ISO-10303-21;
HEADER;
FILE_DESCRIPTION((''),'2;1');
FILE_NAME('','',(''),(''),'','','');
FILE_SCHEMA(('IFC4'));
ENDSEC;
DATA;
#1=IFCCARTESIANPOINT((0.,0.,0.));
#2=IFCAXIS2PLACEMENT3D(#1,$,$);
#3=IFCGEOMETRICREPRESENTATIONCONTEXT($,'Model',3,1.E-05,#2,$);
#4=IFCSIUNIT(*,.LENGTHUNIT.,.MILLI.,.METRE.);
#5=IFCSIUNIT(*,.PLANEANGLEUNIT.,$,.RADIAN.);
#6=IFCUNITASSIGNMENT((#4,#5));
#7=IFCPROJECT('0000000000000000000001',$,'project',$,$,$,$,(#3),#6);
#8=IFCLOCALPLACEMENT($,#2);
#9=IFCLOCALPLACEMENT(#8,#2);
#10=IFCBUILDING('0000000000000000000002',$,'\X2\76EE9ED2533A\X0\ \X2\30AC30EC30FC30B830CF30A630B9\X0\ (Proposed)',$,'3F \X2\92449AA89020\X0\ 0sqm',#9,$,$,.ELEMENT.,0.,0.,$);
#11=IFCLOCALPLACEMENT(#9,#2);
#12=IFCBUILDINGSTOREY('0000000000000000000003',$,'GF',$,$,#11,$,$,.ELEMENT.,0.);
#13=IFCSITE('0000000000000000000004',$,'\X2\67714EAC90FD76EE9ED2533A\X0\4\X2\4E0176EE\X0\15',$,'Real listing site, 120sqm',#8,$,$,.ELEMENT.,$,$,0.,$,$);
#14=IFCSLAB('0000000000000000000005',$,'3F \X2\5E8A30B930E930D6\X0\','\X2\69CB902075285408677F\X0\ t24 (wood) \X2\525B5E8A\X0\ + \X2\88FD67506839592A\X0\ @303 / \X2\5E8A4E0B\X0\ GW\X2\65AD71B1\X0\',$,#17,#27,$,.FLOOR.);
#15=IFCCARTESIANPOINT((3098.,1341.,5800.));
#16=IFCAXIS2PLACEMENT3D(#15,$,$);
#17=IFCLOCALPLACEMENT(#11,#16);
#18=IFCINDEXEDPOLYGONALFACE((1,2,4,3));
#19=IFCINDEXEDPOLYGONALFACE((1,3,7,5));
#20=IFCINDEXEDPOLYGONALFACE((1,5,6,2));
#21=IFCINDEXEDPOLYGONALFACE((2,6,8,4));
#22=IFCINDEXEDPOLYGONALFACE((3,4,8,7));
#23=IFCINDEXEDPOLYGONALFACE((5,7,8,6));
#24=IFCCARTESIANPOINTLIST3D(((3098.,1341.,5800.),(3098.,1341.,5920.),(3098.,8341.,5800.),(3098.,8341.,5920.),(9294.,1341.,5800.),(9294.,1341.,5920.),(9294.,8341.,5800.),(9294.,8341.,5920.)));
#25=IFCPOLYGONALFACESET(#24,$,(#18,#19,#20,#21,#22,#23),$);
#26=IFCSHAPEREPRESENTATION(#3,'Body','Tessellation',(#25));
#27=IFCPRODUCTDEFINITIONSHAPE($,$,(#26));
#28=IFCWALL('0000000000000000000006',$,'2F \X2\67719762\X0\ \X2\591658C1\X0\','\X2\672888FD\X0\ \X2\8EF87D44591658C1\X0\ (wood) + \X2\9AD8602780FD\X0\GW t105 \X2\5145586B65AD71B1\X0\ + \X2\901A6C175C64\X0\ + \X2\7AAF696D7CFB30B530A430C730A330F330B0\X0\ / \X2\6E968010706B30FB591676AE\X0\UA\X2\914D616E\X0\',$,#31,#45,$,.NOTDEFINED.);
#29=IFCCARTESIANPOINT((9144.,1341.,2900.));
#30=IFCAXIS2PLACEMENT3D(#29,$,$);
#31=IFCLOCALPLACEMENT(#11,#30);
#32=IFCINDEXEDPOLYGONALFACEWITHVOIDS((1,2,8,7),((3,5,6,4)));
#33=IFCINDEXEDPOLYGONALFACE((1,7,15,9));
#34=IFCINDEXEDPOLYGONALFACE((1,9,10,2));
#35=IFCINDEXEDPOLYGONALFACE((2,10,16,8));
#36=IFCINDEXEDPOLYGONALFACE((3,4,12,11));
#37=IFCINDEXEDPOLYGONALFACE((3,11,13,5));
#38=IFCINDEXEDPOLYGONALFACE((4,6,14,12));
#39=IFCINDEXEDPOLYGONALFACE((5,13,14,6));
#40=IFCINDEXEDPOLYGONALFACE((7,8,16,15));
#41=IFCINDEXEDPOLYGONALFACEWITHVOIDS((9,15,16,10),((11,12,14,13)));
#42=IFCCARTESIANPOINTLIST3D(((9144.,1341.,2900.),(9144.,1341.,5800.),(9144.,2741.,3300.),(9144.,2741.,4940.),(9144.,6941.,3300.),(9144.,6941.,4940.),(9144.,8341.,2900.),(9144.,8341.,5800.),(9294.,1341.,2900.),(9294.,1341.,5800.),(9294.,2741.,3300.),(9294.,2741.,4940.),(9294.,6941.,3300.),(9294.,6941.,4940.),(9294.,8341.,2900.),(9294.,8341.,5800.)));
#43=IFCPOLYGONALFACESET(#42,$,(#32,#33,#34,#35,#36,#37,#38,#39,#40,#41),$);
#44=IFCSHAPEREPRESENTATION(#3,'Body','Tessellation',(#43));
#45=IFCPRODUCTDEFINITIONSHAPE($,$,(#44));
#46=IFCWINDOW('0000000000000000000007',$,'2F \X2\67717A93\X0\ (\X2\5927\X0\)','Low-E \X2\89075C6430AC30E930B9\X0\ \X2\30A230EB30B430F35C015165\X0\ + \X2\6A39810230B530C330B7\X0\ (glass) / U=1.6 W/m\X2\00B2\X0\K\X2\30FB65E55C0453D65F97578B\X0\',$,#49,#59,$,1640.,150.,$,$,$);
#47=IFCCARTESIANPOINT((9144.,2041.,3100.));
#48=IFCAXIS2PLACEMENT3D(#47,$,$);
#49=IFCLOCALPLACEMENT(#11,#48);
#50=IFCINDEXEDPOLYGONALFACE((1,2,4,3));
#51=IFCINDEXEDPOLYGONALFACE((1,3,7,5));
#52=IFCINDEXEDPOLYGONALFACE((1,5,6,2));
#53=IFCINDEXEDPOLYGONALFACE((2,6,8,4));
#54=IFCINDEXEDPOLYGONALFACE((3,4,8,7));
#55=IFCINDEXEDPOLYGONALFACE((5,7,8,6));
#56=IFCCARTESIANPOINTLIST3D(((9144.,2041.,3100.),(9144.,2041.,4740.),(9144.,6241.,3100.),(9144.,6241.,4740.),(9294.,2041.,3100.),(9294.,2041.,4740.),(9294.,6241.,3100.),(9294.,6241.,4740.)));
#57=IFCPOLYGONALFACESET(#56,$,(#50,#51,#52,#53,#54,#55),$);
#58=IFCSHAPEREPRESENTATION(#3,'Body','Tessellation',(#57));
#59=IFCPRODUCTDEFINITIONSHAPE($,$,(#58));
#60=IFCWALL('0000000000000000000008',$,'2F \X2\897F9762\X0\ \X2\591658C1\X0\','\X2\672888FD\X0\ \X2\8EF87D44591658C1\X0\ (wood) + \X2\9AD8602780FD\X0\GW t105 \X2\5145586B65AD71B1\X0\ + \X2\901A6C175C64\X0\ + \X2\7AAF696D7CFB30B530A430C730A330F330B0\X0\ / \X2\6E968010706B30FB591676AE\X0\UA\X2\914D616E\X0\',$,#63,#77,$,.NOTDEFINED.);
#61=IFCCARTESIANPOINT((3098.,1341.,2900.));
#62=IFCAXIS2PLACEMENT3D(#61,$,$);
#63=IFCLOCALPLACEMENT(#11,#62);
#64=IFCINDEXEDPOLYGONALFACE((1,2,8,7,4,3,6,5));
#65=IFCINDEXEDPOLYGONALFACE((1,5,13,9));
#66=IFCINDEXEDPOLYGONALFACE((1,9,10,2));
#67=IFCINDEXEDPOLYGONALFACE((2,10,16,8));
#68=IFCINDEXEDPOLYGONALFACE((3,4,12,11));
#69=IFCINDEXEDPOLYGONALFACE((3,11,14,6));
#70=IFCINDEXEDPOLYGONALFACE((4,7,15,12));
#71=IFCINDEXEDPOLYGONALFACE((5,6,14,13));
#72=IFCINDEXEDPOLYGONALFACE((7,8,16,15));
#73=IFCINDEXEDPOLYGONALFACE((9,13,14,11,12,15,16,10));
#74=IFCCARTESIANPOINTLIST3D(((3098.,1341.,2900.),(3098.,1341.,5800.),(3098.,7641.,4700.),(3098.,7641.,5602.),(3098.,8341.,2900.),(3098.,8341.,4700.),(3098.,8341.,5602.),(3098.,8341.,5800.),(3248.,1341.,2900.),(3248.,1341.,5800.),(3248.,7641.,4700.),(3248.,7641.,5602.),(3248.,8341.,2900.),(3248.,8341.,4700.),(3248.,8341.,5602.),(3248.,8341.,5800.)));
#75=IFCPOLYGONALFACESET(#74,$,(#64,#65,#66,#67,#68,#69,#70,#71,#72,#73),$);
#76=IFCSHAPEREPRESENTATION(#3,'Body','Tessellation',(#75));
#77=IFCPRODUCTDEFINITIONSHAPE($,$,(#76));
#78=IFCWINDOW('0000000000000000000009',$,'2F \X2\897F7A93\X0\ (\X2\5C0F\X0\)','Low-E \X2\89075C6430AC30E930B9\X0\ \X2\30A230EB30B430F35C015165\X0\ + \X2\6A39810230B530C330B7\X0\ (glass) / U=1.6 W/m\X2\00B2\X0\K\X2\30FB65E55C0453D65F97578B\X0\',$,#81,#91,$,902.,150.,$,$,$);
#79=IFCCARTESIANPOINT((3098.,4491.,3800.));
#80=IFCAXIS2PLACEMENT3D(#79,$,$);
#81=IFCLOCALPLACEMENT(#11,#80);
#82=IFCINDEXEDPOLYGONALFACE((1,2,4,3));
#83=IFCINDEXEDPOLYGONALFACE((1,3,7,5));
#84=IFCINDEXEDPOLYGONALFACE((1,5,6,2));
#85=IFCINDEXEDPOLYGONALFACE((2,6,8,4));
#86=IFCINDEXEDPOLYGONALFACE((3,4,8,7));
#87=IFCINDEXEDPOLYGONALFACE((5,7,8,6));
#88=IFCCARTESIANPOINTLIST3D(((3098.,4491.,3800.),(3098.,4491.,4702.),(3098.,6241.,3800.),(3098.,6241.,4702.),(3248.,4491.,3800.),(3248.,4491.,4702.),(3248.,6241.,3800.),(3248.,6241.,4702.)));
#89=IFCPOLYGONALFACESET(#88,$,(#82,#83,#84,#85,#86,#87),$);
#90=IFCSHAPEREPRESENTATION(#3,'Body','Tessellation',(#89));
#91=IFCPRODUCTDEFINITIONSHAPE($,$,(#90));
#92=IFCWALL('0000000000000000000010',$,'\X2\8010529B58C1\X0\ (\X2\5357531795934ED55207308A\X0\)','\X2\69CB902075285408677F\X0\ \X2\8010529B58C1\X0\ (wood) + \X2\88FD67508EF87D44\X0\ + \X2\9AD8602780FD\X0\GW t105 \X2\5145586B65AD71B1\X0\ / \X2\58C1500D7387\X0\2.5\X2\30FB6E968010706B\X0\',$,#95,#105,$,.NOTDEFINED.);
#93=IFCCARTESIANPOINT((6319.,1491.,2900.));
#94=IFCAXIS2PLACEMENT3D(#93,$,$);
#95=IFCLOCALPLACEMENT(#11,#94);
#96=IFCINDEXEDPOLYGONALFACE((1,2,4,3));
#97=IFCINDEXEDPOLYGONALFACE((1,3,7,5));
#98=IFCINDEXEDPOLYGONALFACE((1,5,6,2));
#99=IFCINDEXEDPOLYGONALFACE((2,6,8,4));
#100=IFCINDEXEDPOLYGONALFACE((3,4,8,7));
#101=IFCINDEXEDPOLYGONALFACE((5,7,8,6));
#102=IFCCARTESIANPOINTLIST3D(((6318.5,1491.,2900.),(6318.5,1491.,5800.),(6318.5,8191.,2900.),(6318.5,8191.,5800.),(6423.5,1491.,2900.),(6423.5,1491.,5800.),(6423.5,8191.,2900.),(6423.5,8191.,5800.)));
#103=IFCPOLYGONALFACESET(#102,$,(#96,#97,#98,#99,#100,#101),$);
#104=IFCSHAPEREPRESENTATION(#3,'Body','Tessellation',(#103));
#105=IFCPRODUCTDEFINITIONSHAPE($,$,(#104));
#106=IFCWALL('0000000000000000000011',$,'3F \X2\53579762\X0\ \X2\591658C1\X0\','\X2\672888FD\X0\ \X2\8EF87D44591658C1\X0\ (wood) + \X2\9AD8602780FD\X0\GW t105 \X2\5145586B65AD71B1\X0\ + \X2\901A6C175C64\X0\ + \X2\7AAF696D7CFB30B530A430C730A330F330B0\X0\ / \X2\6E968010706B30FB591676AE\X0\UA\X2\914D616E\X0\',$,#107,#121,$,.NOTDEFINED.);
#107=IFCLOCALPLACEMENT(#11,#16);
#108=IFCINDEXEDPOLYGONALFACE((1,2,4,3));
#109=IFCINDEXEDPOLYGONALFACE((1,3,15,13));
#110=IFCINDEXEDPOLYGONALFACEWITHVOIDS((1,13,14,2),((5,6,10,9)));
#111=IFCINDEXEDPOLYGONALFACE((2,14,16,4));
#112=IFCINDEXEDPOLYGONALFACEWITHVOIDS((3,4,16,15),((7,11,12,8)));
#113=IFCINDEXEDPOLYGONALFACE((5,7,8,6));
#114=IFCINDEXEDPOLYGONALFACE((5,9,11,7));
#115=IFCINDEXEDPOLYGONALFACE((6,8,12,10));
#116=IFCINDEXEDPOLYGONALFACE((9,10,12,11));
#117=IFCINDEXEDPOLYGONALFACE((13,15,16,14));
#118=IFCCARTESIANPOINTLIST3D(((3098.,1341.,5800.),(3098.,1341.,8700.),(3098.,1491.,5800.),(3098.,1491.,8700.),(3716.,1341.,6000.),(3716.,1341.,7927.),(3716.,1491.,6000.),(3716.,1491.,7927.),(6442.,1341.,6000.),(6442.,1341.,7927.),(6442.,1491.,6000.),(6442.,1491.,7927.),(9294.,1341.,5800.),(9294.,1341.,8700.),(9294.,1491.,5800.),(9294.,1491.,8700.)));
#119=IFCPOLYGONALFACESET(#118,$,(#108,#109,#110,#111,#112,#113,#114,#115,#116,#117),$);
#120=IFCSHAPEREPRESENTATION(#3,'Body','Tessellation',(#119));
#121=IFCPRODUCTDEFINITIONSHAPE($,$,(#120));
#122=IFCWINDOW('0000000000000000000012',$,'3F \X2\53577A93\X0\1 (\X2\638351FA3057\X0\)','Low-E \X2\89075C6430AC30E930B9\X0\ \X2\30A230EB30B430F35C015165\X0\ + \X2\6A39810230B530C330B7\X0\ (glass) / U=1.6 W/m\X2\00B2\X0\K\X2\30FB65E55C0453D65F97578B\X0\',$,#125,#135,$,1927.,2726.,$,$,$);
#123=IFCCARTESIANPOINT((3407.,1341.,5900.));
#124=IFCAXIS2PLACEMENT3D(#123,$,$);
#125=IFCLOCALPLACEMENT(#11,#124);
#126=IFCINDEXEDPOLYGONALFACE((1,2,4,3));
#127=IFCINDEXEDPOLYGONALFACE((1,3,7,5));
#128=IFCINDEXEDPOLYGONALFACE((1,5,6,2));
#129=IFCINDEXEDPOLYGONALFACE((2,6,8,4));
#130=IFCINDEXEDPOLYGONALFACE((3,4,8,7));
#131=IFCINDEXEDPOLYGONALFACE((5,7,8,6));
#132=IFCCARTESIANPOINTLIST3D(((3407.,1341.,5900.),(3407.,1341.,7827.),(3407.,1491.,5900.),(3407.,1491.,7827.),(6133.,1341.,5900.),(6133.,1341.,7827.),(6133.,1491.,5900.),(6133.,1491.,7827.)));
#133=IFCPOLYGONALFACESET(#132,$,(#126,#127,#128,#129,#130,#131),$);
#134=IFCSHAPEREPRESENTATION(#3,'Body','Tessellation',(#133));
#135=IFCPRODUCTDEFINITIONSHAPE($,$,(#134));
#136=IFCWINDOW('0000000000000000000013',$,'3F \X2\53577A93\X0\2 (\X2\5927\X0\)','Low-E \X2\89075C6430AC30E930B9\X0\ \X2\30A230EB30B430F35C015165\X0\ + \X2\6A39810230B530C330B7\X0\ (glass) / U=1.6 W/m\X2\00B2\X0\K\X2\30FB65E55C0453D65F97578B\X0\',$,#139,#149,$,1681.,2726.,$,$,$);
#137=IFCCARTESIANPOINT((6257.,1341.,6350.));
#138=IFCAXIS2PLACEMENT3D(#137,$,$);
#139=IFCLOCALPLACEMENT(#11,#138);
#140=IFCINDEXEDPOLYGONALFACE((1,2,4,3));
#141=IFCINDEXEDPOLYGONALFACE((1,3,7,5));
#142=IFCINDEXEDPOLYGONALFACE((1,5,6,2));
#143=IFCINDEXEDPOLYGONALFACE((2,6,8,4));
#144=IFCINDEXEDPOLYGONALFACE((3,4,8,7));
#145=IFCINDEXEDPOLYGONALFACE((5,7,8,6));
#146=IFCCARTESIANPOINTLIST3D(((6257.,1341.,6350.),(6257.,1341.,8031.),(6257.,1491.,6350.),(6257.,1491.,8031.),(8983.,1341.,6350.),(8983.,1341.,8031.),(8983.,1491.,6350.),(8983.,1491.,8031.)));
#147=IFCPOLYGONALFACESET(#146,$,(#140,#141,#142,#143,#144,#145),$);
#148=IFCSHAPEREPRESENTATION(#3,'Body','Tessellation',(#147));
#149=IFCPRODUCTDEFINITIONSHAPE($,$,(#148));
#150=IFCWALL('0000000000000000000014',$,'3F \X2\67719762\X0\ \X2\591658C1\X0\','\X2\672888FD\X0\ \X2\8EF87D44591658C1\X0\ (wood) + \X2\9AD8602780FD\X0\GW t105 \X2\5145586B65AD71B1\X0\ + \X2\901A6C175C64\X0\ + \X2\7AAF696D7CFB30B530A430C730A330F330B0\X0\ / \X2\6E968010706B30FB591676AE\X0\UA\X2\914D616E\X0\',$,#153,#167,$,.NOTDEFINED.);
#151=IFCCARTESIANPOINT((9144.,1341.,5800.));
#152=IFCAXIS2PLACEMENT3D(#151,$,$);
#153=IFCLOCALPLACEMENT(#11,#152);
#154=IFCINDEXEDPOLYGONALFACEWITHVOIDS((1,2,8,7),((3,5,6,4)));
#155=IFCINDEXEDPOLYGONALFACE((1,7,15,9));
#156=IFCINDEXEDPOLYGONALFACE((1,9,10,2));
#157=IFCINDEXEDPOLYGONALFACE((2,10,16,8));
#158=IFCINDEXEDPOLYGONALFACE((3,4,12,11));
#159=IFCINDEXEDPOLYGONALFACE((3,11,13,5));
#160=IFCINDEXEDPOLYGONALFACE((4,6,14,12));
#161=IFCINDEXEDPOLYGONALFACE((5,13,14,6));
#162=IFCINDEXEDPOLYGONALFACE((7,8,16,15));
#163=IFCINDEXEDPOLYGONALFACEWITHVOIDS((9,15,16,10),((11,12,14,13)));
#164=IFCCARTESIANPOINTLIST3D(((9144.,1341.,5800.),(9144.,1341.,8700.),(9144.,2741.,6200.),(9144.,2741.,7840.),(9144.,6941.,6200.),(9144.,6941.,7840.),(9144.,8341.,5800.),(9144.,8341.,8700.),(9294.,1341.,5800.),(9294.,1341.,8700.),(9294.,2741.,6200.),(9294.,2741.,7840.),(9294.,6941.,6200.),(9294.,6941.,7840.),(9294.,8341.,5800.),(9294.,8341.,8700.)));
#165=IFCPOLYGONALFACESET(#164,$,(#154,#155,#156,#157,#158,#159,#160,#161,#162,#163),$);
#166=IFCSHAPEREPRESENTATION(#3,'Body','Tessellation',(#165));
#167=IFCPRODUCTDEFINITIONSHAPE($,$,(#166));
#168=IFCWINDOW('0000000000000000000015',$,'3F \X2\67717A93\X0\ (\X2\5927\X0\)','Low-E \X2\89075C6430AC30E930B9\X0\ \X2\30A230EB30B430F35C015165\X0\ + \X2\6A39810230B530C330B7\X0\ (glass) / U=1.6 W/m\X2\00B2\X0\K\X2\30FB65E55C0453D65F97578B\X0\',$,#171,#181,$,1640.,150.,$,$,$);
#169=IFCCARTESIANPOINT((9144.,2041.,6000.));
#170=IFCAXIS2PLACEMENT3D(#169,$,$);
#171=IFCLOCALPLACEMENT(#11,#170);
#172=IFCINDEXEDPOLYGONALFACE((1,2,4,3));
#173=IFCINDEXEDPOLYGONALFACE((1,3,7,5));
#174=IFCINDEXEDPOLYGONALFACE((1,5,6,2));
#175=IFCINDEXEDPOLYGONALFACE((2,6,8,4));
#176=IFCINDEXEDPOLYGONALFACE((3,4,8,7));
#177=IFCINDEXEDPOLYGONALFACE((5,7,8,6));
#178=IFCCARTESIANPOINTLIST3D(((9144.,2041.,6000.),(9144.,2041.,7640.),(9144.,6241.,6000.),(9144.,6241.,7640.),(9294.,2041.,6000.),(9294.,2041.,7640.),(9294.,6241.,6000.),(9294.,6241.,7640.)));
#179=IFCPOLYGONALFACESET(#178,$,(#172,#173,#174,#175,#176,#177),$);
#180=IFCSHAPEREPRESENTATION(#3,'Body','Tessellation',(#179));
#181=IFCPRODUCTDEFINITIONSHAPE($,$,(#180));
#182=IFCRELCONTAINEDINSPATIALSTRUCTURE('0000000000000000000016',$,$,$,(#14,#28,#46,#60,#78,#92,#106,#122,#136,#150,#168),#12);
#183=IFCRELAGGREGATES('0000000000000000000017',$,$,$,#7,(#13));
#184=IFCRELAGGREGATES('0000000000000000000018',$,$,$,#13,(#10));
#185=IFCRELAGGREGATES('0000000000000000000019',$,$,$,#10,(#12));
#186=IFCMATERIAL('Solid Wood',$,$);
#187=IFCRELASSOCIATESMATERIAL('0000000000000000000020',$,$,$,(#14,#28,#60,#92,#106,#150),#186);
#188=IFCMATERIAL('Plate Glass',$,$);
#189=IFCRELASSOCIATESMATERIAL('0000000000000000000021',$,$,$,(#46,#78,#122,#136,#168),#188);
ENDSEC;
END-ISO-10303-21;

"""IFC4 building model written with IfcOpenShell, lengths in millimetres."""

from ifc_helpers import new_model, si_unit, frame, frame_2d, origin, place, context, project, spatial, rectangle, extrude, material, element, fill, save


model = new_model("IFC4")

# Units and contexts
model_context = context("Model", 3, precision=1e-05, world=origin())
ifc_project = project(units=[si_unit("LENGTHUNIT", "METRE", prefix="MILLI"), si_unit("PLANEANGLEUNIT", "RADIAN")], contexts=[model_context])

# Site, building, storey
site_placement = place(None, origin())
site = spatial("IfcSite", under=ifc_project, at=site_placement, Name="東京都目黒区4丁目15", ObjectType="Real listing site, 120sqm", CompositionType="ELEMENT", RefElevation=0.0)
building_placement = place(site_placement, origin())
building = spatial("IfcBuilding", under=site, at=building_placement, Name="目黒区 ガレージハウス (Proposed)", ObjectType="3F 鉄骨造 0sqm", CompositionType="ELEMENT", ElevationOfRefHeight=0.0, ElevationOfTerrain=0.0)
storey_placement = place(building_placement, origin())
storey = spatial("IfcBuildingStorey", under=building, at=storey_placement, Name="GF", CompositionType="ELEMENT", Elevation=0.0)

# Slab
ifc_material_1 = material(Name="Solid Wood")
slab_placement = place(storey_placement, frame((3098.0, 1341.0, 5800.0)))
element("IfcSlab", 1, at=slab_placement, inside=storey, material=ifc_material_1, Name="3F 床スラブ", Description="構造用合板 t24 (wood) 剛床 + 製材根太 @303 / 床下 GW断熱", PredefinedType="FLOOR", context=model_context, shape_type="SweptSolid", body=[
    extrude(rectangle(XDim=6196.0, YDim=7000.0, at=frame_2d((3098.0, 3500.0))), frame((3098.0, 1341.0, 5800.0)), (0.0, 0.0, 1.0), 120.0),
])

# Walls, openings, windows
wall_1_placement = place(storey_placement, frame((9144.0, 1341.0, 2900.0)))
wall_1 = element("IfcWall", 2, at=wall_1_placement, inside=storey, material=ifc_material_1, Name="2F 東面 外壁", Description="木製 軸組外壁 (wood) + 高性能GW t105 充填断熱 + 通気層 + 窯業系サイディング / 準耐火・外皮UA配慮", PredefinedType="NOTDEFINED", context=model_context, shape_type="SweptSolid", body=[
    extrude(rectangle(XDim=150.0, YDim=7000.0, at=frame_2d((75.0, 3500.0))), frame((9144.0, 1341.0, 2900.0)), (0.0, 0.0, 1.0), 2900.0),
])
opening_1_placement = place(storey_placement, frame((9144.0, 2041.0, 3100.0)))
opening_1 = element("IfcOpeningElement", 3, at=opening_1_placement, cuts=wall_1, PredefinedType="NOTDEFINED", context=model_context, shape_type="SweptSolid", body=[
    extrude(rectangle(XDim=150.0, YDim=4200.0, at=frame_2d((75.0, 2100.0))), frame((9144.0, 2041.0, 3100.0)), (0.0, 0.0, 1.0), 1640.0),
])
ifc_material_2 = material(Name="Plate Glass")
window_1_placement = place(storey_placement, frame((9144.0, 2041.0, 3100.0)))
window_1 = element("IfcWindow", 4, at=window_1_placement, inside=storey, material=ifc_material_2, Name="2F 東窓 (大)", Description="Low-E 複層ガラス アルゴン封入 + 樹脂サッシ (glass) / U=1.6 W/m²K・日射取得型", OverallHeight=1640.0, OverallWidth=150.0, context=model_context, shape_type="SweptSolid", body=[
    extrude(rectangle(XDim=150.0, YDim=4200.0, at=frame_2d((75.0, 2100.0))), frame((9144.0, 2041.0, 3100.0)), (0.0, 0.0, 1.0), 1640.0),
])
fill(opening_1, window_1)
wall_2_placement = place(storey_placement, frame((3098.0, 1341.0, 2900.0)))
wall_2 = element("IfcWall", 5, at=wall_2_placement, inside=storey, material=ifc_material_1, Name="2F 西面 外壁", Description="木製 軸組外壁 (wood) + 高性能GW t105 充填断熱 + 通気層 + 窯業系サイディング / 準耐火・外皮UA配慮", PredefinedType="NOTDEFINED", context=model_context, shape_type="SweptSolid", body=[
    extrude(rectangle(XDim=150.0, YDim=7000.0, at=frame_2d((75.0, 3500.0))), frame((3098.0, 1341.0, 2900.0)), (0.0, 0.0, 1.0), 2900.0),
])
opening_2_placement = place(storey_placement, frame((3098.0, 4491.0, 3800.0)))
opening_2 = element("IfcOpeningElement", 6, at=opening_2_placement, cuts=wall_2, PredefinedType="NOTDEFINED", context=model_context, shape_type="SweptSolid", body=[
    extrude(rectangle(XDim=150.0, YDim=1750.0, at=frame_2d((75.0, 875.0))), frame((3098.0, 4491.0, 3800.0)), (0.0, 0.0, 1.0), 902.0),
])
window_2_placement = place(storey_placement, frame((3098.0, 4491.0, 3800.0)))
window_2 = element("IfcWindow", 7, at=window_2_placement, inside=storey, material=ifc_material_2, Name="2F 西窓 (小)", Description="Low-E 複層ガラス アルゴン封入 + 樹脂サッシ (glass) / U=1.6 W/m²K・日射取得型", OverallHeight=902.0, OverallWidth=150.0, context=model_context, shape_type="SweptSolid", body=[
    extrude(rectangle(XDim=150.0, YDim=1750.0, at=frame_2d((75.0, 875.0))), frame((3098.0, 4491.0, 3800.0)), (0.0, 0.0, 1.0), 902.0),
])
fill(opening_2, window_2)

# Wall
wall_3_placement = place(storey_placement, frame((6319.0, 1491.0, 2900.0)))
element("IfcWall", 8, at=wall_3_placement, inside=storey, material=ifc_material_1, Name="耐力壁 (南北間仕切り)", Description="構造用合板 耐力壁 (wood) + 製材軸組 + 高性能GW t105 充填断熱 / 壁倍率2.5・準耐火", PredefinedType="NOTDEFINED", context=model_context, shape_type="SweptSolid", body=[
    extrude(rectangle(XDim=105.0, YDim=6700.0, at=frame_2d((52.0, 3350.0))), frame((6319.0, 1491.0, 2900.0)), (0.0, 0.0, 1.0), 2900.0),
])

# Wall, openings, windows
wall_4_placement = place(storey_placement, frame((3098.0, 1341.0, 5800.0)))
wall_4 = element("IfcWall", 9, at=wall_4_placement, inside=storey, material=ifc_material_1, Name="3F 南面 外壁", Description="木製 軸組外壁 (wood) + 高性能GW t105 充填断熱 + 通気層 + 窯業系サイディング / 準耐火・外皮UA配慮", PredefinedType="NOTDEFINED", context=model_context, shape_type="SweptSolid", body=[
    extrude(rectangle(XDim=6196.0, YDim=150.0, at=frame_2d((3098.0, 75.0))), frame((3098.0, 1341.0, 5800.0)), (0.0, 0.0, 1.0), 2900.0),
])
opening_3_placement = place(storey_placement, frame((3407.0, 1341.0, 5900.0)))
opening_3 = element("IfcOpeningElement", 10, at=opening_3_placement, cuts=wall_4, PredefinedType="NOTDEFINED", context=model_context, shape_type="SweptSolid", body=[
    extrude(rectangle(XDim=2726.0, YDim=150.0, at=frame_2d((1363.0, 75.0))), frame((3407.0, 1341.0, 5900.0)), (0.0, 0.0, 1.0), 1927.0),
])
opening_4_placement = place(storey_placement, frame((6257.0, 1341.0, 6350.0)))
opening_4 = element("IfcOpeningElement", 11, at=opening_4_placement, cuts=wall_4, PredefinedType="NOTDEFINED", context=model_context, shape_type="SweptSolid", body=[
    extrude(rectangle(XDim=2726.0, YDim=150.0, at=frame_2d((1363.0, 75.0))), frame((6257.0, 1341.0, 6350.0)), (0.0, 0.0, 1.0), 1681.0),
])
window_3_placement = place(storey_placement, frame((3407.0, 1341.0, 5900.0)))
window_3 = element("IfcWindow", 12, at=window_3_placement, inside=storey, material=ifc_material_2, Name="3F 南窓1 (掃出し)", Description="Low-E 複層ガラス アルゴン封入 + 樹脂サッシ (glass) / U=1.6 W/m²K・日射取得型", OverallHeight=1927.0, OverallWidth=2726.0, context=model_context, shape_type="SweptSolid", body=[
    extrude(rectangle(XDim=2726.0, YDim=150.0, at=frame_2d((1363.0, 75.0))), frame((3407.0, 1341.0, 5900.0)), (0.0, 0.0, 1.0), 1927.0),
])
fill(opening_3, window_3)
window_4_placement = place(storey_placement, frame((6257.0, 1341.0, 6350.0)))
window_4 = element("IfcWindow", 13, at=window_4_placement, inside=storey, material=ifc_material_2, Name="3F 南窓2 (大)", Description="Low-E 複層ガラス アルゴン封入 + 樹脂サッシ (glass) / U=1.6 W/m²K・日射取得型", OverallHeight=1681.0, OverallWidth=2726.0, context=model_context, shape_type="SweptSolid", body=[
    extrude(rectangle(XDim=2726.0, YDim=150.0, at=frame_2d((1363.0, 75.0))), frame((6257.0, 1341.0, 6350.0)), (0.0, 0.0, 1.0), 1681.0),
])
fill(opening_4, window_4)

# Wall, opening, window
wall_5_placement = place(storey_placement, frame((9144.0, 1341.0, 5800.0)))
wall_5 = element("IfcWall", 14, at=wall_5_placement, inside=storey, material=ifc_material_1, Name="3F 東面 外壁", Description="木製 軸組外壁 (wood) + 高性能GW t105 充填断熱 + 通気層 + 窯業系サイディング / 準耐火・外皮UA配慮", PredefinedType="NOTDEFINED", context=model_context, shape_type="SweptSolid", body=[
    extrude(rectangle(XDim=150.0, YDim=7000.0, at=frame_2d((75.0, 3500.0))), frame((9144.0, 1341.0, 5800.0)), (0.0, 0.0, 1.0), 2900.0),
])
opening_5_placement = place(storey_placement, frame((9144.0, 2041.0, 6000.0)))
opening_5 = element("IfcOpeningElement", 15, at=opening_5_placement, cuts=wall_5, PredefinedType="NOTDEFINED", context=model_context, shape_type="SweptSolid", body=[
    extrude(rectangle(XDim=150.0, YDim=4200.0, at=frame_2d((75.0, 2100.0))), frame((9144.0, 2041.0, 6000.0)), (0.0, 0.0, 1.0), 1640.0),
])
window_5_placement = place(storey_placement, frame((9144.0, 2041.0, 6000.0)))
window_5 = element("IfcWindow", 16, at=window_5_placement, inside=storey, material=ifc_material_2, Name="3F 東窓 (大)", Description="Low-E 複層ガラス アルゴン封入 + 樹脂サッシ (glass) / U=1.6 W/m²K・日射取得型", OverallHeight=1640.0, OverallWidth=150.0, context=model_context, shape_type="SweptSolid", body=[
    extrude(rectangle(XDim=150.0, YDim=4200.0, at=frame_2d((75.0, 2100.0))), frame((9144.0, 2041.0, 6000.0)), (0.0, 0.0, 1.0), 1640.0),
])
fill(opening_5, window_5)

save(model, "model.ifc")
